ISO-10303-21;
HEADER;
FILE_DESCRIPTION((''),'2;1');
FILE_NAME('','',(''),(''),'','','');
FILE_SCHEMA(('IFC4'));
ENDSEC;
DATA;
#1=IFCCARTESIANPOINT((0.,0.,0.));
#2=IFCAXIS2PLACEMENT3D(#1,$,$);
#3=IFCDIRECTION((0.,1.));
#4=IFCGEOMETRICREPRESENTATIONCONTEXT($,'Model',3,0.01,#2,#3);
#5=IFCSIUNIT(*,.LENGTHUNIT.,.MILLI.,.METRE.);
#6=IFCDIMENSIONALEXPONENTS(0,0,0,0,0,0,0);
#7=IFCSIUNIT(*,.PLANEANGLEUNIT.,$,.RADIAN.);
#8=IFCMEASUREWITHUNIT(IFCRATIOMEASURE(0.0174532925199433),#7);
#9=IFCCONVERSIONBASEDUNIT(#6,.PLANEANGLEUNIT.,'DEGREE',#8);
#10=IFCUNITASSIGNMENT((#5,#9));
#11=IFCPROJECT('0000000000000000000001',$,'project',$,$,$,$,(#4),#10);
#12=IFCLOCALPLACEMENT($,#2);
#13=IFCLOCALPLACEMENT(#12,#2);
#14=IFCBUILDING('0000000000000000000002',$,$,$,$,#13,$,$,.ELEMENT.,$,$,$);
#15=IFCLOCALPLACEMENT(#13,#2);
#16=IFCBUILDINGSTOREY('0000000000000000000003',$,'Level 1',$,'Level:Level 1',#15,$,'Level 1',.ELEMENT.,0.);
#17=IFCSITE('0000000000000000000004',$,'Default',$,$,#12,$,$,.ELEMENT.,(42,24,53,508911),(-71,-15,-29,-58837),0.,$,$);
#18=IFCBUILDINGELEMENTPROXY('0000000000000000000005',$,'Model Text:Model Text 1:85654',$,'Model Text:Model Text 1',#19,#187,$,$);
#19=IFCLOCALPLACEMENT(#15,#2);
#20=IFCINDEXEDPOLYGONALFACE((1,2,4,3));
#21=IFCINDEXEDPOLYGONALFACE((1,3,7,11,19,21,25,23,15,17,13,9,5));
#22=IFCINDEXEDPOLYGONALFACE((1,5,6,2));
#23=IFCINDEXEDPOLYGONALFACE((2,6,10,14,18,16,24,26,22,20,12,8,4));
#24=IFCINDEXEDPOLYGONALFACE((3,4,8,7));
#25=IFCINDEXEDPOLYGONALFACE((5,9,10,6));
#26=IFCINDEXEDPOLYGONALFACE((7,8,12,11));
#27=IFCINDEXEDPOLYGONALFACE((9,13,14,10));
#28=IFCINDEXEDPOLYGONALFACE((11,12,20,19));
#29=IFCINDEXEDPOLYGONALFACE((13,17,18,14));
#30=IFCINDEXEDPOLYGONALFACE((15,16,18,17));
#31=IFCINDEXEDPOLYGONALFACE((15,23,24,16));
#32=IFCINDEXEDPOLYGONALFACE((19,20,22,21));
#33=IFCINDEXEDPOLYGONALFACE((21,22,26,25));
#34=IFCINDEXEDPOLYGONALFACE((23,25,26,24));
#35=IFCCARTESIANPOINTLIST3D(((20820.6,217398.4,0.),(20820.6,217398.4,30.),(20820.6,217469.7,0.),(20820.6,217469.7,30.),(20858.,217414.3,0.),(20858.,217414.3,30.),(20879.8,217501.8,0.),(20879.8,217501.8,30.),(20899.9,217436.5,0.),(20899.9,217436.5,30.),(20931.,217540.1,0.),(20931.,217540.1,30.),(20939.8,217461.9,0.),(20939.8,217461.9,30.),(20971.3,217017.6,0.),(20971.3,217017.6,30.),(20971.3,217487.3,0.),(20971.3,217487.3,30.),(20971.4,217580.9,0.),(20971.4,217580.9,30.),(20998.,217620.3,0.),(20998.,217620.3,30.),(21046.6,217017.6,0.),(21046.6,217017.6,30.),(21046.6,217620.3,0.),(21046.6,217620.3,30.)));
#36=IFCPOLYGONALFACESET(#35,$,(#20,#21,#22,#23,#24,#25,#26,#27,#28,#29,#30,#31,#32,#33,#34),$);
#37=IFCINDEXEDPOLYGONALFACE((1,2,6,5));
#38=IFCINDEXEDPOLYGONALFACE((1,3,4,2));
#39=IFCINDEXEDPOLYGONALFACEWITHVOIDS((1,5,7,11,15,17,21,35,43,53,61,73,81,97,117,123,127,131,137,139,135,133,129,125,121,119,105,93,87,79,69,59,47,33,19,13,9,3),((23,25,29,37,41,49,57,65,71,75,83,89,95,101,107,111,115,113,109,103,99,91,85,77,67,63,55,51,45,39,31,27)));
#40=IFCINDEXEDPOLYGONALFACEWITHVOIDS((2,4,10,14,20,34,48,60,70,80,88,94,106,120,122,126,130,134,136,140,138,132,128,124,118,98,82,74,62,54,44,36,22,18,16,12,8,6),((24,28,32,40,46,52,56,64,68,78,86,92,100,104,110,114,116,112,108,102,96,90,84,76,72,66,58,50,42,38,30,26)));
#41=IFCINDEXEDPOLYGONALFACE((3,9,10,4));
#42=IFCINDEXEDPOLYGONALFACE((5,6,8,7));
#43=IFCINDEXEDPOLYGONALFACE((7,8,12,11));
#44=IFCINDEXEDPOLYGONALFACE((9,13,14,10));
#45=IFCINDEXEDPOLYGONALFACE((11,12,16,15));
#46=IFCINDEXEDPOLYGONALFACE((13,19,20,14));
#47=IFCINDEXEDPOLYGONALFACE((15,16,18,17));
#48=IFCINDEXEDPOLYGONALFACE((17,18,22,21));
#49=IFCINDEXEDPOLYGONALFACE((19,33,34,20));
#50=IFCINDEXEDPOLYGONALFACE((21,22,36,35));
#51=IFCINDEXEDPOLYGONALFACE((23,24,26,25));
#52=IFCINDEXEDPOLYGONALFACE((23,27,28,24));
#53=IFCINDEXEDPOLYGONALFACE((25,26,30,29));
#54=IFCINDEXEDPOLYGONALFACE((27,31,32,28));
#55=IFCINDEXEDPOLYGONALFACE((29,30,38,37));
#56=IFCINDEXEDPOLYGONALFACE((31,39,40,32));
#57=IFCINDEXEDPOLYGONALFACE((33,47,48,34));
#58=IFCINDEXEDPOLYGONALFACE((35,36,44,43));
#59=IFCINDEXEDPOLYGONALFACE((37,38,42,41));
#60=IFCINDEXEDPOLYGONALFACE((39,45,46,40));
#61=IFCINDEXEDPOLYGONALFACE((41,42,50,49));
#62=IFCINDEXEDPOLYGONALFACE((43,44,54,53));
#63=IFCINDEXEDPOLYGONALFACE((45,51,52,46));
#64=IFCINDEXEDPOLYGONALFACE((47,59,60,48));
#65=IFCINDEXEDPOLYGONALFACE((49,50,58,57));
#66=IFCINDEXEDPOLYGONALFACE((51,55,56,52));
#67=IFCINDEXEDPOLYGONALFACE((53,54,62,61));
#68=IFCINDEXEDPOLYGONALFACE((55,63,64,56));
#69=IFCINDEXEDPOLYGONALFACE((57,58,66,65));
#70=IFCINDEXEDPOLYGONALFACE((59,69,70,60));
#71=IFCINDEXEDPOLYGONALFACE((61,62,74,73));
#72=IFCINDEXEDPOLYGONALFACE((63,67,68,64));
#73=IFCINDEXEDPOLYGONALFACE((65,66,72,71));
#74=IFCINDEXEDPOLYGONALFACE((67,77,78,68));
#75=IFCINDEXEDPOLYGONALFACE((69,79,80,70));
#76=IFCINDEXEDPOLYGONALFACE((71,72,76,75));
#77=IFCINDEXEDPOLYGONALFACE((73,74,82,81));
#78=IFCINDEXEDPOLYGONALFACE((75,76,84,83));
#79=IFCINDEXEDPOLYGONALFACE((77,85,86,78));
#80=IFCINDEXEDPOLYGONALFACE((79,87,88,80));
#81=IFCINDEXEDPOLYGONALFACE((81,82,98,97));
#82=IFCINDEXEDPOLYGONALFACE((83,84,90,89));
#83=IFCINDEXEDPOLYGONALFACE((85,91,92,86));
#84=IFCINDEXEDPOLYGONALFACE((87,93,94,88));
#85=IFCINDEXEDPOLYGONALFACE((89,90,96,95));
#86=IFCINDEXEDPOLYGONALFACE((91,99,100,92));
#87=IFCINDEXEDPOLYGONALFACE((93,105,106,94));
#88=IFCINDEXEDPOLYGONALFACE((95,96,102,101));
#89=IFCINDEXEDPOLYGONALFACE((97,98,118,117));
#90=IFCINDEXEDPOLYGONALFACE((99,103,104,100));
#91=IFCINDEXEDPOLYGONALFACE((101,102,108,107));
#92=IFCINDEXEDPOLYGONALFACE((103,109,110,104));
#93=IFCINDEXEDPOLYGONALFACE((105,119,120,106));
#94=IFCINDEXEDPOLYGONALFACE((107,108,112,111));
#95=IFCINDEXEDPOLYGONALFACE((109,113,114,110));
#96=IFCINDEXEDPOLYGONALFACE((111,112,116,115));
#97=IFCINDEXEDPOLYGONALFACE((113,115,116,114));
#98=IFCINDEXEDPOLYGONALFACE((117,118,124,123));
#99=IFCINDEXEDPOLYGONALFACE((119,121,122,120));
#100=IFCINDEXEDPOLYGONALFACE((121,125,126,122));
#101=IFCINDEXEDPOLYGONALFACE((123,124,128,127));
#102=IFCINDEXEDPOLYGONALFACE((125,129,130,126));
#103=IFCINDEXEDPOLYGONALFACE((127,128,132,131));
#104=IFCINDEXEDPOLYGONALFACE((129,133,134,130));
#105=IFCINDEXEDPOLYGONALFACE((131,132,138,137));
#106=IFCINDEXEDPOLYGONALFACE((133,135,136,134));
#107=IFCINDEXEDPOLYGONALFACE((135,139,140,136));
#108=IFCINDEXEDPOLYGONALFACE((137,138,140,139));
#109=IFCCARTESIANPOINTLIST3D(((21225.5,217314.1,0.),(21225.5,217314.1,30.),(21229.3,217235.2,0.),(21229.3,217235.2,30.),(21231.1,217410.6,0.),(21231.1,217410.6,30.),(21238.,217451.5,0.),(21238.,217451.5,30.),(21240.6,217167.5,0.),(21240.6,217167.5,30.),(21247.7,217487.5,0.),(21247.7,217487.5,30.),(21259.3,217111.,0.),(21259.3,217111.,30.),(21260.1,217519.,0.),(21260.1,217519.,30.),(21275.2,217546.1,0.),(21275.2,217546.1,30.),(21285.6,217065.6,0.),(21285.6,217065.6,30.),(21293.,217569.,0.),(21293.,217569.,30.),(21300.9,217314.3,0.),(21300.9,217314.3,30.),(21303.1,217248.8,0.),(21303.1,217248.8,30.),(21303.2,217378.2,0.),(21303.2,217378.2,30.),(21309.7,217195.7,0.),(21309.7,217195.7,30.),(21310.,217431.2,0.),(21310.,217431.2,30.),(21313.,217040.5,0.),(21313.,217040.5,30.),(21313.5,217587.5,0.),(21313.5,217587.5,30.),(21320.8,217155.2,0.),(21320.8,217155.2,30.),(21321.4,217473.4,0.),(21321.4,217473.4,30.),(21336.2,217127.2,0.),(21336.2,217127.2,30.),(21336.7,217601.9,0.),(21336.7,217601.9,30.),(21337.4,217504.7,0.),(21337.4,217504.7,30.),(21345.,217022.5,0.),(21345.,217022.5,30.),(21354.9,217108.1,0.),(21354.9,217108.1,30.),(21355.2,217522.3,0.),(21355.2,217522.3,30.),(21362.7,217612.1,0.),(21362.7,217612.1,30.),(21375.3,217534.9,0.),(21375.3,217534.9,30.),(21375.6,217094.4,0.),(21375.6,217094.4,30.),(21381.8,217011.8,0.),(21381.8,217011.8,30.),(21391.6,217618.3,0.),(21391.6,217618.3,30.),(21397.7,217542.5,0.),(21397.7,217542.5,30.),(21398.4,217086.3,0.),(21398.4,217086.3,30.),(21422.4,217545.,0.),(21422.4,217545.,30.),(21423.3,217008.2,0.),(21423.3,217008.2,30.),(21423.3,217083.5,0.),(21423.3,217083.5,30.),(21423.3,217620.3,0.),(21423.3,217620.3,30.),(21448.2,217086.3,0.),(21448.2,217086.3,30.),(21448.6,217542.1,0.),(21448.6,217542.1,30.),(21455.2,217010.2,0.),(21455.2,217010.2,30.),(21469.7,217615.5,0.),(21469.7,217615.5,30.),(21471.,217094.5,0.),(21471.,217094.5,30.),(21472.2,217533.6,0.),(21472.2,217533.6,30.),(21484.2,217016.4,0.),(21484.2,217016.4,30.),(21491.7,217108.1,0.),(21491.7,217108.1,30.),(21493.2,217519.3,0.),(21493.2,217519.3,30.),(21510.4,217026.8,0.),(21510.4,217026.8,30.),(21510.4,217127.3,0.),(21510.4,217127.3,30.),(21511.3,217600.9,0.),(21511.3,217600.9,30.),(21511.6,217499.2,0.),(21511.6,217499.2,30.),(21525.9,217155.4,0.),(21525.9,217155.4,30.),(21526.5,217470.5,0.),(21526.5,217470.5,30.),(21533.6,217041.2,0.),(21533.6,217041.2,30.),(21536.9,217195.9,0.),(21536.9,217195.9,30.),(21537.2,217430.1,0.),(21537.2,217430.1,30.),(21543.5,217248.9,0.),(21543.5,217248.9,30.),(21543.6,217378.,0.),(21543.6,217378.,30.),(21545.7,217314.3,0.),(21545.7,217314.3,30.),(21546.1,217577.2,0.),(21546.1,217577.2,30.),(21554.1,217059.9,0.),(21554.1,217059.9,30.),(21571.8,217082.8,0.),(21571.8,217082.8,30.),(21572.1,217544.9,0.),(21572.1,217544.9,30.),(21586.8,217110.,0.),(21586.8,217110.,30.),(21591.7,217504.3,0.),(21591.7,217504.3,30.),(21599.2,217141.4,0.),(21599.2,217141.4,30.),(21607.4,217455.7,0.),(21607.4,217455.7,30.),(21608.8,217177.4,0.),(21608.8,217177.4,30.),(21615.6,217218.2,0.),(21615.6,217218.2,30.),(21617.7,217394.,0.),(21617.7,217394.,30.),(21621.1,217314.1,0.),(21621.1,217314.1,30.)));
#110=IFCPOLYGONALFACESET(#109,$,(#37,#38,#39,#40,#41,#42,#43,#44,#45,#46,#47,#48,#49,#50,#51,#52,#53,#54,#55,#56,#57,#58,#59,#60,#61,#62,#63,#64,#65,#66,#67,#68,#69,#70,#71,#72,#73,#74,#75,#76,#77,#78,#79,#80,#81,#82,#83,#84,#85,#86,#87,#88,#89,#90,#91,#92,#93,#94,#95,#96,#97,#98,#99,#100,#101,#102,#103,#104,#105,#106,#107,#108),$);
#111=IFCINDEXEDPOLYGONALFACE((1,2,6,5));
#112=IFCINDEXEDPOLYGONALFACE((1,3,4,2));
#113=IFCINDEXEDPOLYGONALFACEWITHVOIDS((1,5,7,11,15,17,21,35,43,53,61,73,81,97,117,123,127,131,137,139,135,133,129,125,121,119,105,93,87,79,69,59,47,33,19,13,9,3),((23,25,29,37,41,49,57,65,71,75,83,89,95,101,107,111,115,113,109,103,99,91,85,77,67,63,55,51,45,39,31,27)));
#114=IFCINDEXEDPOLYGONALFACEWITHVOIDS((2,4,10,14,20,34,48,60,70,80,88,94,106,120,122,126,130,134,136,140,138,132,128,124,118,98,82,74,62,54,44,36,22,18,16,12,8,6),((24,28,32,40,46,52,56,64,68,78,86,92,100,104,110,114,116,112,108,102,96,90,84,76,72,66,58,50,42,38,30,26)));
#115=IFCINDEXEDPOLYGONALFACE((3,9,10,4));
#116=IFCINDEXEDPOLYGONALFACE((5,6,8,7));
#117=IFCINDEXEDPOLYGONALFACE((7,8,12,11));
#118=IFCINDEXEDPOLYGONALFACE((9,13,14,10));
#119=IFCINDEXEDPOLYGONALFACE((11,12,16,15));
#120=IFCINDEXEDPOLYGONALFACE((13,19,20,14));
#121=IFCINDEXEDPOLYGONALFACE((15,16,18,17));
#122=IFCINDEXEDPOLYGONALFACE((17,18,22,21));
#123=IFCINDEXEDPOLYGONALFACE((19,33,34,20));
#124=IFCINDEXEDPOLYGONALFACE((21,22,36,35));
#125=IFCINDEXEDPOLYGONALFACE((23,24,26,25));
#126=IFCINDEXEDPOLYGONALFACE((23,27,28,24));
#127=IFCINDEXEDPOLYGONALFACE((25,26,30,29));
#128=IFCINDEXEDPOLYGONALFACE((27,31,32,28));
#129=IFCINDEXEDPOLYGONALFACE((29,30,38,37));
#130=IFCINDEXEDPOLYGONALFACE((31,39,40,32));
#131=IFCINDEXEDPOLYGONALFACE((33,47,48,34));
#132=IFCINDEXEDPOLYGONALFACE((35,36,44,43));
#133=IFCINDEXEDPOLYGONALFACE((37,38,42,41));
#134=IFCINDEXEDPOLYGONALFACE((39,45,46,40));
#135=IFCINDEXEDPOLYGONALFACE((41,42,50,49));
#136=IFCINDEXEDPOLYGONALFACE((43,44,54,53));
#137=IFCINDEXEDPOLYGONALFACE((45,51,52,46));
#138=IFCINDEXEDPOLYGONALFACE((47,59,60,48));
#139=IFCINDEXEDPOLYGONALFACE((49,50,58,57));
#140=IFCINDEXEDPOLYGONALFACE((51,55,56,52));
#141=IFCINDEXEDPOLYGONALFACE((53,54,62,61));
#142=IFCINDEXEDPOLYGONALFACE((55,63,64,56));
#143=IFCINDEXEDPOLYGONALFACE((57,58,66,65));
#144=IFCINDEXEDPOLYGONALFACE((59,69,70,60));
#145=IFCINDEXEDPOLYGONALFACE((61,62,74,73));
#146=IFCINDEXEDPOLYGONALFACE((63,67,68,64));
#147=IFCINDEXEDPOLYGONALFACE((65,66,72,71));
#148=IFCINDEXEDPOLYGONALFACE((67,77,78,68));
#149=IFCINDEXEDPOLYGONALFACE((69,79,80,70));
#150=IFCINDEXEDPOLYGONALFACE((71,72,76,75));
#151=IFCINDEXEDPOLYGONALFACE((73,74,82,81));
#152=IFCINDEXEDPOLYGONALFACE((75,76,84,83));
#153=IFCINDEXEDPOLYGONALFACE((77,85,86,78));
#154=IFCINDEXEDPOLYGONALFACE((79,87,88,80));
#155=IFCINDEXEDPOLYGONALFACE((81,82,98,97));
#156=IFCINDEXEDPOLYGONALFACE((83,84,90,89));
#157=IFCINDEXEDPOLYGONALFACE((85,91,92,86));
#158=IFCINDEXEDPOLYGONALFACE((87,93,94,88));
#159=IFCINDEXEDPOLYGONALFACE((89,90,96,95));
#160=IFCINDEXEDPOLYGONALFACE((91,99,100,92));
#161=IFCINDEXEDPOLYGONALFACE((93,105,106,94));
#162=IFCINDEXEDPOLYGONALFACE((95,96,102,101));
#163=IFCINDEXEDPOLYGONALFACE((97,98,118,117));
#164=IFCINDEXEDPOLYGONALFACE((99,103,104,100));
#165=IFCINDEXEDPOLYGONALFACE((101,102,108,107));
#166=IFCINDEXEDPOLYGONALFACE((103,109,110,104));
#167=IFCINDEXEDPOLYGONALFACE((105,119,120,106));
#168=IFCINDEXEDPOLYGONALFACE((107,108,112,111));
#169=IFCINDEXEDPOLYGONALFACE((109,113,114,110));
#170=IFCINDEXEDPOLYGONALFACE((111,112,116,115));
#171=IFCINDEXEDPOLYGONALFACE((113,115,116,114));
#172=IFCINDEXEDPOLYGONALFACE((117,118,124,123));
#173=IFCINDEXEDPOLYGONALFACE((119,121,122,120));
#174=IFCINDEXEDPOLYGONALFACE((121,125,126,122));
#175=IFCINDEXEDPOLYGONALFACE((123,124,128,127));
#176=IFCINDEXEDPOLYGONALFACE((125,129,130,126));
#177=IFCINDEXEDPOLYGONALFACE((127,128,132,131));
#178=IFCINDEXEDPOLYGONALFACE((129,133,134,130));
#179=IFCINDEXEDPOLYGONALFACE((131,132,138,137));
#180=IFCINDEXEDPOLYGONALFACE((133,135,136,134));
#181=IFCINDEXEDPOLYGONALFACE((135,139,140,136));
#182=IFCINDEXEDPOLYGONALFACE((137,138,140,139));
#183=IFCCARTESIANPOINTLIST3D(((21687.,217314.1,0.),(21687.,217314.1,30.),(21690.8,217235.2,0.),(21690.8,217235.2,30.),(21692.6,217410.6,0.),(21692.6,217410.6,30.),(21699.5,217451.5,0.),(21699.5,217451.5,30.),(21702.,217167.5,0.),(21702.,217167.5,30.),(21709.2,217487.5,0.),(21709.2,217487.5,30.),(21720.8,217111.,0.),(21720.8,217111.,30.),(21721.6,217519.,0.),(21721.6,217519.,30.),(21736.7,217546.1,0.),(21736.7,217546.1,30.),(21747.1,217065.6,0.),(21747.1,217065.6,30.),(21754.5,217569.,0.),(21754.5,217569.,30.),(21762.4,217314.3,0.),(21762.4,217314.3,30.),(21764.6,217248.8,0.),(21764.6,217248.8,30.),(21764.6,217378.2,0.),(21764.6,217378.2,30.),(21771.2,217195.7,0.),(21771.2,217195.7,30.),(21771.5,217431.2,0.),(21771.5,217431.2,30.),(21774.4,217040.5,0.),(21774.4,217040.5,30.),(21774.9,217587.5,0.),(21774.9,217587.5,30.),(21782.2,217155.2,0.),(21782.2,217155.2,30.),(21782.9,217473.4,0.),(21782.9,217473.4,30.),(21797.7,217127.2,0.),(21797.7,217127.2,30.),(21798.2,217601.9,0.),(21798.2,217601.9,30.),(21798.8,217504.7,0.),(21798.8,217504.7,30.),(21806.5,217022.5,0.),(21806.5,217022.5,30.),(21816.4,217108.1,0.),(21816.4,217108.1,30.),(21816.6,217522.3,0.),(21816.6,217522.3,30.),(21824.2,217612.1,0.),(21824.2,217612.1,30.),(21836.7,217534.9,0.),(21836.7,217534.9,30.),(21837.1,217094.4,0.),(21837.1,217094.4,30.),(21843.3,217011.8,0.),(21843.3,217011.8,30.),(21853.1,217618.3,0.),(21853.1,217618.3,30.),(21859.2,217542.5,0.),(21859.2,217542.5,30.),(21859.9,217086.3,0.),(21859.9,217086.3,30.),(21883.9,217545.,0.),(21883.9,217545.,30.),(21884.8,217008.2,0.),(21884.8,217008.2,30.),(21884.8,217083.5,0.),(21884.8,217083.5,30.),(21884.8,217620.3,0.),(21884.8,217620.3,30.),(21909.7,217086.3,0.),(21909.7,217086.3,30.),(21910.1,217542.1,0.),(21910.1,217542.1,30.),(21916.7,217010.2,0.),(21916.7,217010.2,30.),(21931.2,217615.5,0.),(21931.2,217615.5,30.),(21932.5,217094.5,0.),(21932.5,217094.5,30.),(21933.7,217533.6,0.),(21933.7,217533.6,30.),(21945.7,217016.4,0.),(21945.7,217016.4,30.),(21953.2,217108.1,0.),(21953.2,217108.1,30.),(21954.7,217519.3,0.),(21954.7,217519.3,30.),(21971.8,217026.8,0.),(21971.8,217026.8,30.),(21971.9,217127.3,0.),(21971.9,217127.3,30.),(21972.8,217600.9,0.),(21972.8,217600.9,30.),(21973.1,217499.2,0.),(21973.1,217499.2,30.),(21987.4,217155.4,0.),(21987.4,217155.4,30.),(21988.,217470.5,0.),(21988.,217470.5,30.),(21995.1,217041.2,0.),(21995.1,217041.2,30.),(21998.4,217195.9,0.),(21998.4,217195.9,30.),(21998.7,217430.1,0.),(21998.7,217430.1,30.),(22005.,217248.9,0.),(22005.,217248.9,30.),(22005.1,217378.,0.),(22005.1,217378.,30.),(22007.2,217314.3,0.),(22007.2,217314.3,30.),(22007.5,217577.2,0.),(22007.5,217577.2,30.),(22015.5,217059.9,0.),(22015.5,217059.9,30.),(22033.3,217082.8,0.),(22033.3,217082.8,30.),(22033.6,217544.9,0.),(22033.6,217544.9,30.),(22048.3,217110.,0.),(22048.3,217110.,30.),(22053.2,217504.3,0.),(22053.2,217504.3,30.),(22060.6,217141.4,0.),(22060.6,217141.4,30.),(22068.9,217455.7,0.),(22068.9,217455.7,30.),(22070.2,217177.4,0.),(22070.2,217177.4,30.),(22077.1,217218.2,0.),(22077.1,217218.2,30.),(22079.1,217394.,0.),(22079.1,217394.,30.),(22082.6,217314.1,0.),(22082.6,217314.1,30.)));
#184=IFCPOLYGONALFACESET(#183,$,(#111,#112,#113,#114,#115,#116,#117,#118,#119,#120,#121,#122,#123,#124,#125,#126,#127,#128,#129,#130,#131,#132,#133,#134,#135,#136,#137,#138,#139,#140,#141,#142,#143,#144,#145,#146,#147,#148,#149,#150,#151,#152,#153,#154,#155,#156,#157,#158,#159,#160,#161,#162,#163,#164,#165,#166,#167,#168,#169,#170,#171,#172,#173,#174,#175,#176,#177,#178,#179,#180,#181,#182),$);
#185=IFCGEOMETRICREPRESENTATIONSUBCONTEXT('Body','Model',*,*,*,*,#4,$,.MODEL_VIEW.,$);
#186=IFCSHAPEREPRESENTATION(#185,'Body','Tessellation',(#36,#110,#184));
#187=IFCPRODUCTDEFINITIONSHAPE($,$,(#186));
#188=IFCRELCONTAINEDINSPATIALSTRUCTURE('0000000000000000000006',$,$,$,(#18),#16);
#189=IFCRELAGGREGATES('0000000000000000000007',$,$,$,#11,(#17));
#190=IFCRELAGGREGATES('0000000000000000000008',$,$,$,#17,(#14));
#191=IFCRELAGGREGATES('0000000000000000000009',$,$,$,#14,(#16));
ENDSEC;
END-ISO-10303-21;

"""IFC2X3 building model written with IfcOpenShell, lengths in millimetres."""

from ifc_helpers import new_model, entity, si_unit, converted_unit, direction, frame, origin, place, context, subcontext, project, spatial, polyline, outline, extrude, element, save


model = new_model("IFC2X3")

# Units and contexts
model_context = context("Model", 3, precision=0.01, world=origin(), true_north=direction((0.0, 1.0)))
body_context = subcontext(model_context, "Body", "Model", "MODEL_VIEW")
ifc_project = project(units=[si_unit("LENGTHUNIT", "METRE", prefix="MILLI"), converted_unit("PLANEANGLEUNIT", "DEGREE", entity("IfcRatioMeasure", 0.0174532925199433), si_unit("PLANEANGLEUNIT", "RADIAN"), dimensions=[0, 0, 0, 0, 0, 0, 0])], contexts=[model_context])

# Site, building, storey
site_placement = place(None, origin())
site = spatial("IfcSite", under=ifc_project, at=site_placement, Name="Default", CompositionType="ELEMENT", RefLatitude=(42, 24, 53, 508911), RefLongitude=(-71, -15, -29, -58837), RefElevation=0.0)
building_placement = place(site_placement, origin())
building = spatial("IfcBuilding", under=site, at=building_placement, CompositionType="ELEMENT")
storey_placement = place(building_placement, origin())
storey = spatial("IfcBuildingStorey", under=building, at=storey_placement, Name="Level 1", ObjectType="Level:Level 1", LongName="Level 1", CompositionType="ELEMENT", Elevation=0.0)

# Building element proxy
proxy_1_placement = place(storey_placement, origin())
element("IfcBuildingElementProxy", 1, at=proxy_1_placement, inside=storey, Name="Model Text:Model Text 1:85654", ObjectType="Model Text:Model Text 1", context=body_context, shape_type="SweptSolid", body=[
    extrude(outline(polyline([(-410.6, -111.6), (192.1, -111.6), (192.1, -63.1), (152.7, -36.4), (111.9, 4.0), (73.6, 55.2), (41.4, 114.4), (-29.8, 114.4), (-13.9, 77.0), (8.3, 35.1), (33.7, -4.8), (59.1, -36.3), (-410.6, -36.3), (-410.6, -111.6)])), frame((20935.0, 217428.2, 0.0), z_axis=(0.0, 0.0, 1.0), x_axis=(0.0, 1.0, 0.0)), (0.0, 0.0, 1.0), 30.0),
    extrude(outline(polyline([(-10.6, -198.7), (68.3, -198.7), (136.5, -190.7), (193.9, -174.7), (240.5, -150.6), (266.9, -124.4), (286.3, -93.2), (298.8, -57.0), (304.3, -15.7), (303.8, 16.2), (299.0, 45.5), (289.9, 72.1), (276.6, 96.0), (258.9, 117.3), (236.9, 136.2), (210.4, 152.5), (179.6, 166.3), (144.1, 177.6), (103.7, 186.3), (8.2, 196.4), (-71.8, 196.7), (-134.0, 189.4), (-183.3, 176.1), (-224.7, 158.4), (-258.2, 133.9), (-283.5, 100.3), (-300.1, 59.5), (-307.1, 13.4), (-306.6, -18.4), (-301.8, -47.5), (-292.8, -74.0), (-279.6, -97.9), (-262.0, -119.2), (-240.0, -138.1), (-213.6, -154.5), (-182.8, -168.4), (-147.3, -179.8), (-106.7, -188.6), (-10.6, -198.7)]), holes=[polyline([(-7.2, -123.5), (-71.0, -118.2), (-123.6, -108.8), (-165.2, -95.4), (-195.7, -78.0), (-212.4, -59.4), (-224.1, -38.7), (-230.6, -15.9), (-231.9, 8.9), (-227.8, 35.0), (-218.1, 58.1), (-202.8, 78.4), (-182.0, 95.8), (-152.6, 109.4), (-111.7, 118.1), (-59.4, 122.0), (4.4, 121.1), (69.6, 115.8), (122.2, 106.7), (162.2, 93.7), (189.5, 77.0), (207.7, 57.4), (220.4, 36.0), (227.5, 12.8), (229.1, -12.1), (225.2, -36.8), (215.9, -59.2), (201.3, -79.3), (181.4, -97.1), (152.6, -111.2), (111.6, -120.3), (58.3, -124.4), (-7.2, -123.5)])]), frame((21424.6, 217312.9, 0.0), z_axis=(0.0, 0.0, 1.0), x_axis=(0.047515, -0.998871, 0.0)), (0.0, 0.0, 1.0), 30.0),
    extrude(outline(polyline([(-10.6, -198.7), (68.3, -198.7), (136.5, -190.7), (193.9, -174.7), (240.5, -150.6), (266.9, -124.4), (286.3, -93.2), (298.8, -57.0), (304.3, -15.7), (303.8, 16.2), (299.0, 45.5), (289.9, 72.1), (276.6, 96.0), (258.9, 117.3), (236.9, 136.2), (210.4, 152.5), (179.6, 166.3), (144.1, 177.6), (103.7, 186.3), (8.2, 196.4), (-71.8, 196.7), (-134.0, 189.4), (-183.3, 176.1), (-224.7, 158.4), (-258.2, 133.9), (-283.5, 100.3), (-300.1, 59.5), (-307.1, 13.4), (-306.6, -18.4), (-301.8, -47.5), (-292.8, -74.0), (-279.6, -97.9), (-262.0, -119.2), (-240.0, -138.1), (-213.6, -154.5), (-182.8, -168.4), (-147.3, -179.8), (-106.7, -188.6), (-10.6, -198.7)]), holes=[polyline([(-7.2, -123.5), (-71.0, -118.2), (-123.6, -108.8), (-165.2, -95.4), (-195.7, -78.0), (-212.4, -59.4), (-224.1, -38.7), (-230.6, -15.9), (-231.9, 8.9), (-227.8, 35.0), (-218.1, 58.1), (-202.8, 78.4), (-182.0, 95.8), (-152.6, 109.4), (-111.7, 118.1), (-59.4, 122.0), (4.4, 121.1), (69.6, 115.8), (122.2, 106.7), (162.2, 93.7), (189.5, 77.0), (207.7, 57.4), (220.4, 36.0), (227.5, 12.8), (229.1, -12.1), (225.2, -36.8), (215.9, -59.2), (201.3, -79.3), (181.4, -97.1), (152.6, -111.2), (111.6, -120.3), (58.3, -124.4), (-7.2, -123.5)])]), frame((21886.0, 217312.9, 0.0), z_axis=(0.0, 0.0, 1.0), x_axis=(0.047515, -0.998871, 0.0)), (0.0, 0.0, 1.0), 30.0),
])

save(model, "model.ifc")
